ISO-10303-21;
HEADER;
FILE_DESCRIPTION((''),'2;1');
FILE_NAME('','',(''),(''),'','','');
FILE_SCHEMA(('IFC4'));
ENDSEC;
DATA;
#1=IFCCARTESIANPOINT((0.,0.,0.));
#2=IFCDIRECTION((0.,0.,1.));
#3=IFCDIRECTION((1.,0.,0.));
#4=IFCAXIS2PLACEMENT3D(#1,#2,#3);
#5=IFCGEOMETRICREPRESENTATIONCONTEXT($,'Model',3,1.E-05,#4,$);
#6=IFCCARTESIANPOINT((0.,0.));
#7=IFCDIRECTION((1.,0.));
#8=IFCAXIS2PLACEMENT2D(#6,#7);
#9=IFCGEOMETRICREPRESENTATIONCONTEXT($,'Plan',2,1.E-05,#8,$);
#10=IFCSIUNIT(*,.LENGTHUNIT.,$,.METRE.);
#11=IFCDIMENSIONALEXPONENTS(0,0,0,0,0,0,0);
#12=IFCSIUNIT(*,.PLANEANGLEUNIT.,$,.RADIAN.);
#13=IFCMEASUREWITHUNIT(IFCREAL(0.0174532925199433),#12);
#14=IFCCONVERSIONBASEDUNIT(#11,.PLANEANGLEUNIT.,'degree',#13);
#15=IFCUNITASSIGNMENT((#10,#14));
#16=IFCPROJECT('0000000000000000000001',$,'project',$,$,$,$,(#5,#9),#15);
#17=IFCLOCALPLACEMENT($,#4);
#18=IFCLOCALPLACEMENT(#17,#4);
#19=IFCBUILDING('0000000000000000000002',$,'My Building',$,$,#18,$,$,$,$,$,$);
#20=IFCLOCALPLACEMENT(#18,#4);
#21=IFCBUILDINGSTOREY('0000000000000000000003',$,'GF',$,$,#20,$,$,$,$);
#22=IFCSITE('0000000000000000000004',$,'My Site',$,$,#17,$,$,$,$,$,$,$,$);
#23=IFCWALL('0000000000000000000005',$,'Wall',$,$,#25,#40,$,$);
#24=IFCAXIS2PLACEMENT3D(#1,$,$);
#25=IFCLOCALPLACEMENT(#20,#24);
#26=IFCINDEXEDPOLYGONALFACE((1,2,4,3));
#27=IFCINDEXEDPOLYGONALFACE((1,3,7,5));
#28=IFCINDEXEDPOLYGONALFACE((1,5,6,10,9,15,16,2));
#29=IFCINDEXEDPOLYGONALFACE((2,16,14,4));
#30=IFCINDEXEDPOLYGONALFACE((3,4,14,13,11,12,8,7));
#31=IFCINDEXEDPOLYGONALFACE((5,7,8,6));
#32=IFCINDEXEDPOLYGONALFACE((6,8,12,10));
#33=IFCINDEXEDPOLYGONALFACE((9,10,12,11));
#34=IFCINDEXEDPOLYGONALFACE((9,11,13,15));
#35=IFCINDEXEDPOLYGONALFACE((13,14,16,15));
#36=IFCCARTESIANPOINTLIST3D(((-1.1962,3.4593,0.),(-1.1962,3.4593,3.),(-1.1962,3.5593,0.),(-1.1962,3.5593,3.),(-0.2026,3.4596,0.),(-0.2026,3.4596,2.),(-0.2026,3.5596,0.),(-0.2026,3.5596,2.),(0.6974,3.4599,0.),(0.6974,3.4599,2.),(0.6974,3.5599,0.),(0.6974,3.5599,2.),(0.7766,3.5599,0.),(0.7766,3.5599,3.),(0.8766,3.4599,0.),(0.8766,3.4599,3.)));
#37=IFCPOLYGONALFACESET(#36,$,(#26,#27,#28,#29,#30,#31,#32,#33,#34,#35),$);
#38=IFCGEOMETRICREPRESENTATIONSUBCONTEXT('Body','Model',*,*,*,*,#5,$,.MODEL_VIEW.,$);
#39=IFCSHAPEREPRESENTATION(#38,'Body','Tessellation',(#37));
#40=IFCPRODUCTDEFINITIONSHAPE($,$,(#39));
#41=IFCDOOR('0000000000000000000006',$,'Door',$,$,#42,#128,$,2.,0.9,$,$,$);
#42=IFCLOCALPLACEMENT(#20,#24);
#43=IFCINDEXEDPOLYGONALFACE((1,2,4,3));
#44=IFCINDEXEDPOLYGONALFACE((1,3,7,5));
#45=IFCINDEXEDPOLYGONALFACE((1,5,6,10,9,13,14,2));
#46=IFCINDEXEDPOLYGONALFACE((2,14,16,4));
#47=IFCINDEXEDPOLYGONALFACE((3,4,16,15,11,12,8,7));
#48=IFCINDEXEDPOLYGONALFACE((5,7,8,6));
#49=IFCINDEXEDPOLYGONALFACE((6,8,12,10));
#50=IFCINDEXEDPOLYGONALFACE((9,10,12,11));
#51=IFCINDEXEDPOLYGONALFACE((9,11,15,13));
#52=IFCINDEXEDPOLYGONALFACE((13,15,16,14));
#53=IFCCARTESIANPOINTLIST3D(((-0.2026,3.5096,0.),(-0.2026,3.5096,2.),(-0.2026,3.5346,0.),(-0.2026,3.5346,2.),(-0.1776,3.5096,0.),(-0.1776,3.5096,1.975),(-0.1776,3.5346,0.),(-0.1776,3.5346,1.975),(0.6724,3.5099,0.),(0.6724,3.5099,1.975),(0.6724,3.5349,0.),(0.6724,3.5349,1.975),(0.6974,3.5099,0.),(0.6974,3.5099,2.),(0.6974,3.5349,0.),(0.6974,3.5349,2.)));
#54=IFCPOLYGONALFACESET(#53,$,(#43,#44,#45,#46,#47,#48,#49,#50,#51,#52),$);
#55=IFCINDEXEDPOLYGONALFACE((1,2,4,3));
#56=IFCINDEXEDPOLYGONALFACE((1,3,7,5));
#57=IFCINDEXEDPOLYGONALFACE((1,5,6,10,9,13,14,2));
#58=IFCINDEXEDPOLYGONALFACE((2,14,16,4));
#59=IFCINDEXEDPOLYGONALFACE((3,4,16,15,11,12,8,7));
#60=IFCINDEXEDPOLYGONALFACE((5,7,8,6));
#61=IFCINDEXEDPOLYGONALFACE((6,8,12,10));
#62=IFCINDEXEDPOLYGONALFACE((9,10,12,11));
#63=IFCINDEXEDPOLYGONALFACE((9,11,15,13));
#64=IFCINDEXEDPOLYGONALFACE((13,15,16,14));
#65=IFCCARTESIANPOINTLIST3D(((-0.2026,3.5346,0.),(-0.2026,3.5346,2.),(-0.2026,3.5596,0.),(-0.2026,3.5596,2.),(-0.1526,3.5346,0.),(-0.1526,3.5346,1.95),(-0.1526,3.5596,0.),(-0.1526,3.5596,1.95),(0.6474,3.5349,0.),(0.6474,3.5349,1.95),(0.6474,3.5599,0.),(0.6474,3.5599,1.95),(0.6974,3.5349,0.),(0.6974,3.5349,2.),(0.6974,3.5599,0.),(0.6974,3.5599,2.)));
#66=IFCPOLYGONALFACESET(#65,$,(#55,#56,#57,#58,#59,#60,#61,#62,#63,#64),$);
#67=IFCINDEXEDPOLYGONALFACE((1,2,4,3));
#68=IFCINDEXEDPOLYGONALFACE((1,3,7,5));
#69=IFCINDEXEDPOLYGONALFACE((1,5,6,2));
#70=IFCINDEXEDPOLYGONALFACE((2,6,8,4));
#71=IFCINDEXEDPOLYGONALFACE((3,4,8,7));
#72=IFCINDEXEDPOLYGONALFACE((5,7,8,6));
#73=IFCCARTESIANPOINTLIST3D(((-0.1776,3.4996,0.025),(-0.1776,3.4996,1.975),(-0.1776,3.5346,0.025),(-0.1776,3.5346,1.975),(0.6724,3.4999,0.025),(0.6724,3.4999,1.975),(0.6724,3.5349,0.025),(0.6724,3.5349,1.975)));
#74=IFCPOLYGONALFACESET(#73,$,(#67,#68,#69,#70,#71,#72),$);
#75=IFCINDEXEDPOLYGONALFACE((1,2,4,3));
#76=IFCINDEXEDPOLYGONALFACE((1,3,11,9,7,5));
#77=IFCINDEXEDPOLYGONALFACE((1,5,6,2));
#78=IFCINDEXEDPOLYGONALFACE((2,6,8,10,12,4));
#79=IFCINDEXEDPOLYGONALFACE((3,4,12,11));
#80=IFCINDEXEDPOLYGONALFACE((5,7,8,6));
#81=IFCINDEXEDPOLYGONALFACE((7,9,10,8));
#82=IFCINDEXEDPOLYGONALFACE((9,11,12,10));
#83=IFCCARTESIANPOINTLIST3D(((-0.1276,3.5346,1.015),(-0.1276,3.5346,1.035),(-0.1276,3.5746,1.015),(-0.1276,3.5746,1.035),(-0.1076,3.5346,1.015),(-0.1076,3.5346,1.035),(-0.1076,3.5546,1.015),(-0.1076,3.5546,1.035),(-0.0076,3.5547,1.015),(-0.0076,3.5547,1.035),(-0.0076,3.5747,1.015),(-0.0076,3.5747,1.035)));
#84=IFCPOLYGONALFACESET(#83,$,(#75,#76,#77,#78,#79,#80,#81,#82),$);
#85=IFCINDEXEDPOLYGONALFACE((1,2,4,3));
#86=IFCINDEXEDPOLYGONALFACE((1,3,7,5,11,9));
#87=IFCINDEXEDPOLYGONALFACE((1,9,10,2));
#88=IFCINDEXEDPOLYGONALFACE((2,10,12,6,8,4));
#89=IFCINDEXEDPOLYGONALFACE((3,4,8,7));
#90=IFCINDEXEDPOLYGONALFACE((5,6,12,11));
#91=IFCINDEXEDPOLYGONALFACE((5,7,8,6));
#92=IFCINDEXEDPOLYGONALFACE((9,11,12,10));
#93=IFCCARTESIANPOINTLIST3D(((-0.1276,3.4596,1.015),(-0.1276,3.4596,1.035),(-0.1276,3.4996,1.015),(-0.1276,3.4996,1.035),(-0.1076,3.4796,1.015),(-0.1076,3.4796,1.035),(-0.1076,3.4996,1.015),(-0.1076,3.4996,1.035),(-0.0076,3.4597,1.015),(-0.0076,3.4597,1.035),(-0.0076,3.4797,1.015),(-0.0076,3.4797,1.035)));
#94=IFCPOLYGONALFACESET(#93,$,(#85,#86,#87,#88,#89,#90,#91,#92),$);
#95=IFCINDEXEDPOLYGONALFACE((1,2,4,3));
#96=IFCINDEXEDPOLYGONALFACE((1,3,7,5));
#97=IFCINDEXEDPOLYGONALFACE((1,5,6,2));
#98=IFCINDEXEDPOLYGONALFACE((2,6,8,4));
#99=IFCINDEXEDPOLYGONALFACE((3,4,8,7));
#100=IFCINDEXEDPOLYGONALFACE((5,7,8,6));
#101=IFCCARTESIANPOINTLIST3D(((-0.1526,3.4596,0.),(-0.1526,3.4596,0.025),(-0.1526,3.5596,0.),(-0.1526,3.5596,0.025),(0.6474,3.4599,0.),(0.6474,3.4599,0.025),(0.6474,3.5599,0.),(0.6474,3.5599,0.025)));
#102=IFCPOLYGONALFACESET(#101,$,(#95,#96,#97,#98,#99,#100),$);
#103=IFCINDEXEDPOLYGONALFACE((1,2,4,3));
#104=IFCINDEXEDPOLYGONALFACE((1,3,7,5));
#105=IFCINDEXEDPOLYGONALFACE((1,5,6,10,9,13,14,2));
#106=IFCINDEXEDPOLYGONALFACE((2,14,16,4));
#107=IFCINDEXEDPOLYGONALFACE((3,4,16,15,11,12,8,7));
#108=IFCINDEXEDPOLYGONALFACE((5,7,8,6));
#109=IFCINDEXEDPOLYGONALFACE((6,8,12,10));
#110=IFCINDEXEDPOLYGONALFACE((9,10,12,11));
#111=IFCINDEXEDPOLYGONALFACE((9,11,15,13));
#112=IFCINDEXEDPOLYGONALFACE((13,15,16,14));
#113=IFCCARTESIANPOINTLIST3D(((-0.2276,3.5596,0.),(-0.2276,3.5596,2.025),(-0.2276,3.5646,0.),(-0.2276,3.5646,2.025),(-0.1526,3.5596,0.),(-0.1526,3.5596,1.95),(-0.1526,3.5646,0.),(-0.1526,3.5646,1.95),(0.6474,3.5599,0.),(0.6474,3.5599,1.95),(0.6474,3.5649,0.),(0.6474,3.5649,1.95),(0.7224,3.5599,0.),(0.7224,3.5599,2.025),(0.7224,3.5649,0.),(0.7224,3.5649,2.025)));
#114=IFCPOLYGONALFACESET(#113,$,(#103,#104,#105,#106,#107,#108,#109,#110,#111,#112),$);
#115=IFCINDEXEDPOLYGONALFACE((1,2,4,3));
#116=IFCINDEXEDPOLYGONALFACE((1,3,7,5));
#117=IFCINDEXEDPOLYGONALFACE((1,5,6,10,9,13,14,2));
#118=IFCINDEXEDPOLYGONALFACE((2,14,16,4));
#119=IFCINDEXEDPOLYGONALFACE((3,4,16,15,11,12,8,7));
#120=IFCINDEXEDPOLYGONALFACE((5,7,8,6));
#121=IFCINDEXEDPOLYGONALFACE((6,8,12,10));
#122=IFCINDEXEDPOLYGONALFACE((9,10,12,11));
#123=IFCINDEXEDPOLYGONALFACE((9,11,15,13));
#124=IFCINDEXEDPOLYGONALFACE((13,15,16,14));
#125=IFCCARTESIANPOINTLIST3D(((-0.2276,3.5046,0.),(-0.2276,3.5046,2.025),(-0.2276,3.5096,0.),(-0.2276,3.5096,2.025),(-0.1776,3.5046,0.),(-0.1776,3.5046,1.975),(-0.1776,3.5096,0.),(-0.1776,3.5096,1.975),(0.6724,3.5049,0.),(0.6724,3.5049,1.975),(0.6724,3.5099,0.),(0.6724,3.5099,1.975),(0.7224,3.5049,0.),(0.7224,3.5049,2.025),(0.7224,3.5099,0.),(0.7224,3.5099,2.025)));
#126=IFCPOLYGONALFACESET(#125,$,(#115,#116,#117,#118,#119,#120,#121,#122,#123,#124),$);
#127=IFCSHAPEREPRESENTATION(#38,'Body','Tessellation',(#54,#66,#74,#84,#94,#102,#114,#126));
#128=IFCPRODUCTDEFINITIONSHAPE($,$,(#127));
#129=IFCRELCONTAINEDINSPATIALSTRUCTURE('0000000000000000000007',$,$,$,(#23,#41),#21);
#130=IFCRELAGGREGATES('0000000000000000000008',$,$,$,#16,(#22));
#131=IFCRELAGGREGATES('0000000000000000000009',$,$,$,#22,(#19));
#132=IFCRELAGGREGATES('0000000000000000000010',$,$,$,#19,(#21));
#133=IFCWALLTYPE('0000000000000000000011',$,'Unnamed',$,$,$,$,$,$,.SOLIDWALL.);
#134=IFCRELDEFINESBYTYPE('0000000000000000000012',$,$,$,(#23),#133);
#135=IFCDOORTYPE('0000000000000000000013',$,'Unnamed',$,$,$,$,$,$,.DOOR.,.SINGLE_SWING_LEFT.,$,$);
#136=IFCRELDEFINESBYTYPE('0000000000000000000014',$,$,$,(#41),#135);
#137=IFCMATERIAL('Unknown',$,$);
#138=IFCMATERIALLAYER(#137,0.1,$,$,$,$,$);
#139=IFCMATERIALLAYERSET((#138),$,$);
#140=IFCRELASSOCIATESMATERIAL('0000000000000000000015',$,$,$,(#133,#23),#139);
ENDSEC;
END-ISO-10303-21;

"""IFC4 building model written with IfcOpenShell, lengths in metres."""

from ifc_helpers import new_model, entity, si_unit, converted_unit, frame, origin_with_axes, origin_2d_with_axis, place, context, subcontext, project, spatial, line, indexed_curve, outline, extrude, shape, source, transform, mapped, material, layer, layer_set, layer_usage, type_object, type_shapes, element, fill, save


model = new_model("IFC4")

# Units and contexts
model_context = context("Model", 3, precision=1e-05, world=origin_with_axes())
plan_context = context("Plan", 2, precision=1e-05, world=origin_2d_with_axis())
body_context_1 = subcontext(model_context, "Body", "Model", "MODEL_VIEW")
body_context_2 = subcontext(plan_context, "Body", "Plan", "PLAN_VIEW")
ifc_project = project(units=[si_unit("LENGTHUNIT", "METRE"), converted_unit("PLANEANGLEUNIT", "degree", entity("IfcReal", 0.0174532925199433), si_unit("PLANEANGLEUNIT", "RADIAN"), dimensions=[0, 0, 0, 0, 0, 0, 0])], contexts=[model_context, plan_context])

# Site, building, storey
site_placement = place(None, origin_with_axes())
site = spatial("IfcSite", under=ifc_project, at=site_placement, Name="My Site")
building_placement = place(site_placement, origin_with_axes())
building = spatial("IfcBuilding", under=site, at=building_placement, Name="My Building")
storey_placement = place(building_placement, origin_with_axes())
storey = spatial("IfcBuildingStorey", under=building, at=storey_placement, Name="GF")

# Shared definitions
ifc_material = material(Name="Unknown")

# Shared definitions
ifc_layer_1 = layer(ifc_material, 0.1)
ifc_layer_set_1 = layer_set([ifc_layer_1])
wall_type = type_object("IfcWallType", Name="Unnamed", PredefinedType="SOLIDWALL", material=ifc_layer_set_1)

# Wall, opening, door
ifc_layer_usage_1 = layer_usage(ifc_layer_set_1, "AXIS2", "POSITIVE", 0.0)
wall_1_placement = place(storey_placement, frame((0.7766, 3.5599, 0.0), z_axis=(0.0, 0.0, 1.0), x_axis=(-1.0, -0.000309, 0.0)))
wall_1 = element("IfcWall", 1, at=wall_1_placement, inside=storey, type_object=wall_type, material=ifc_layer_usage_1, Name="Wall", context=body_context_1, shape_type="SweptSolid", body=[
    extrude(outline(indexed_curve([(0.0, 0.0), (-0.1, 0.1), (1.9728, 0.1), (1.9728, 0.0)], segments=[line(1, 2, 3, 4, 1)])), origin_with_axes(), (0.0, 0.0, 1.0), 3.0),
])
shared_shape_1 = source(origin_with_axes(), body_context_1, "Body", "SweptSolid", [
    extrude(outline(indexed_curve([(0.0, 0.0), (0.9, 0.0), (0.9, 2.0), (0.0, 2.0)], segments=[line(1, 2, 3, 4, 1)])), frame((0.0, -0.6, 0.0), z_axis=(0.0, -1.0, 0.0), x_axis=(1.0, 0.0, 0.0)), (0.0, 0.0, -1.0), 1.2),
])
opening_1_placement = place(wall_1_placement, frame((0.0792, 0.0, 0.0), z_axis=(0.0, 0.0, 1.0), x_axis=(1.0, 0.0, 0.0)))
opening_1 = element("IfcOpeningElement", 2, at=opening_1_placement, cuts=wall_1, PredefinedType="OPENING", context=body_context_1, shape_type="MappedRepresentation", body=[
    mapped(shared_shape_1, transform((0.0, 0.0, 0.0), x_axis=(1.0, 0.0, 0.0), y_axis=(0.0, 1.0, 0.0), z_axis=(0.0, 0.0, 1.0), scale=1.0)),
])
door_type = type_object("IfcDoorType", Name="Unnamed", OperationType="SINGLE_SWING_LEFT", PredefinedType="DOOR")
shared_shape_2 = source(origin_with_axes(), body_context_1, "Body", "SweptSolid", [
    extrude(outline(indexed_curve([(0.0, 0.0), (0.0, 2.0), (0.9, 2.0), (0.9, 0.0), (0.875, 0.0), (0.875, 1.975), (0.025, 1.975), (0.025, 0.0)], segments=[line(1, 2, 3, 4, 5, 6, 7, 8, 1)])), frame((0.0, 0.025, 0.0), z_axis=(0.0, -1.0, 0.0), x_axis=(1.0, 0.0, 0.0)), (0.0, 0.0, -1.0), 0.025),
    extrude(outline(indexed_curve([(0.0, 0.0), (0.0, 2.0), (0.9, 2.0), (0.9, 0.0), (0.85, 0.0), (0.85, 1.95), (0.05, 1.95), (0.05, 0.0)], segments=[line(1, 2, 3, 4, 5, 6, 7, 8, 1)])), frame((0.0, 0.0, 0.0), z_axis=(0.0, -1.0, 0.0), x_axis=(1.0, 0.0, 0.0)), (0.0, 0.0, -1.0), 0.025),
    extrude(outline(indexed_curve([(0.0, 0.0), (0.85, 0.0), (0.85, 0.035), (0.0, 0.035)], segments=[line(1, 2, 3, 4, 1)])), frame((0.025, 0.025, 0.025), z_axis=(0.0, 0.0, 1.0), x_axis=(1.0, 0.0, 0.0)), (0.0, 0.0, 1.0), 1.95),
    extrude(outline(indexed_curve([(0.0, 0.0), (0.0, -0.04), (-0.12, -0.04), (-0.12, -0.02), (-0.02, -0.02), (-0.02, 0.0)], segments=[line(1, 2, 3, 4, 5, 6, 1)])), frame((0.825, 0.025, 1.015), z_axis=(0.0, 0.0, 1.0), x_axis=(1.0, 0.0, 0.0)), (0.0, 0.0, 1.0), 0.02),
    extrude(outline(indexed_curve([(0.0, 0.0), (0.0, 0.04), (-0.12, 0.04), (-0.12, 0.02), (-0.02, 0.02), (-0.02, 0.0)], segments=[line(1, 2, 3, 4, 5, 6, 1)])), frame((0.825, 0.06, 1.015), z_axis=(0.0, 0.0, 1.0), x_axis=(1.0, 0.0, 0.0)), (0.0, 0.0, 1.0), 0.02),
    extrude(outline(indexed_curve([(0.0, 0.0), (0.8, 0.0), (0.8, 0.1), (0.0, 0.1)], segments=[line(1, 2, 3, 4, 1)])), frame((0.05, 0.0, 0.0), z_axis=(0.0, 0.0, 1.0), x_axis=(1.0, 0.0, 0.0)), (0.0, 0.0, 1.0), 0.025),
    extrude(outline(indexed_curve([(0.0, 0.0), (0.0, 2.025), (0.95, 2.025), (0.95, 0.0), (0.875, 0.0), (0.875, 1.95), (0.075, 1.95), (0.075, 0.0)], segments=[line(1, 2, 3, 4, 5, 6, 7, 8, 1)])), frame((-0.025, -0.005, 0.0), z_axis=(0.0, -1.0, 0.0), x_axis=(1.0, 0.0, 0.0)), (0.0, 0.0, -1.0), 0.005),
    extrude(outline(indexed_curve([(0.0, 0.0), (0.0, 2.025), (0.95, 2.025), (0.95, 0.0), (0.9, 0.0), (0.9, 1.975), (0.05, 1.975), (0.05, 0.0)], segments=[line(1, 2, 3, 4, 5, 6, 7, 8, 1)])), frame((-0.025, 0.05, 0.0), z_axis=(0.0, -1.0, 0.0), x_axis=(1.0, 0.0, 0.0)), (0.0, 0.0, -1.0), 0.005),
])
shared_shape_3 = source(origin_with_axes(), body_context_2, "Body", "Curve2D", [
    entity("IfcIndexedPolyCurve", entity("IfcCartesianPointList2D", [[0.0, 0.0], [0.0, 0.05], [0.025, 0.05], [0.025, 0.025], [0.05, 0.025], [0.05, 0.0]]), [entity("IfcLineIndex", [1, 2, 3, 4, 5, 6, 1])]),
    entity("IfcIndexedPolyCurve", entity("IfcCartesianPointList2D", [[0.9, 0.0], [0.9, 0.05], [0.875, 0.05], [0.875, 0.025], [0.85, 0.025], [0.85, 0.0]]), [entity("IfcLineIndex", [1, 2, 3, 4, 5, 6, 1])]),
    entity("IfcTrimmedCurve", entity("IfcEllipse", entity("IfcAxis2Placement2D", entity("IfcCartesianPoint", [0.06, 0.05]), entity("IfcDirection", [1.0, 0.0])), 0.815, 0.85), [entity("IfcCartesianPoint", [0.875, 0.05])], [entity("IfcCartesianPoint", [0.06, 0.9])], True, "CARTESIAN"),
    entity("IfcIndexedPolyCurve", entity("IfcCartesianPointList2D", [[0.025, 0.05], [0.06, 0.05], [0.06, 0.9], [0.025, 0.9]]), [entity("IfcLineIndex", [1, 2, 3, 4, 1])]),
])
type_shapes(door_type, [shared_shape_2, shared_shape_3])
door_placement = place(opening_1_placement, frame((0.0, 0.0, 0.0), z_axis=(0.0, 0.0, 1.0), x_axis=(1.0, 0.0, 0.0)))
door = element("IfcDoor", 3, at=door_placement, inside=storey, type_object=door_type, Name="Door", OverallHeight=2.0, OverallWidth=0.9, shapes=[
    shape(body_context_1, "Body", "MappedRepresentation", [mapped(shared_shape_2, transform((0.0, 0.0, 0.0), x_axis=(1.0, 0.0, 0.0), y_axis=(0.0, 1.0, 0.0), z_axis=(0.0, 0.0, 1.0), scale=1.0))]),
    shape(body_context_2, "Body", "MappedRepresentation", [mapped(shared_shape_3, transform((0.0, 0.0, 0.0), x_axis=(1.0, 0.0, 0.0), y_axis=(0.0, 1.0, 0.0), z_axis=(0.0, 0.0, 1.0), scale=1.0))]),
])
fill(opening_1, door)

save(model, "model.ifc")
